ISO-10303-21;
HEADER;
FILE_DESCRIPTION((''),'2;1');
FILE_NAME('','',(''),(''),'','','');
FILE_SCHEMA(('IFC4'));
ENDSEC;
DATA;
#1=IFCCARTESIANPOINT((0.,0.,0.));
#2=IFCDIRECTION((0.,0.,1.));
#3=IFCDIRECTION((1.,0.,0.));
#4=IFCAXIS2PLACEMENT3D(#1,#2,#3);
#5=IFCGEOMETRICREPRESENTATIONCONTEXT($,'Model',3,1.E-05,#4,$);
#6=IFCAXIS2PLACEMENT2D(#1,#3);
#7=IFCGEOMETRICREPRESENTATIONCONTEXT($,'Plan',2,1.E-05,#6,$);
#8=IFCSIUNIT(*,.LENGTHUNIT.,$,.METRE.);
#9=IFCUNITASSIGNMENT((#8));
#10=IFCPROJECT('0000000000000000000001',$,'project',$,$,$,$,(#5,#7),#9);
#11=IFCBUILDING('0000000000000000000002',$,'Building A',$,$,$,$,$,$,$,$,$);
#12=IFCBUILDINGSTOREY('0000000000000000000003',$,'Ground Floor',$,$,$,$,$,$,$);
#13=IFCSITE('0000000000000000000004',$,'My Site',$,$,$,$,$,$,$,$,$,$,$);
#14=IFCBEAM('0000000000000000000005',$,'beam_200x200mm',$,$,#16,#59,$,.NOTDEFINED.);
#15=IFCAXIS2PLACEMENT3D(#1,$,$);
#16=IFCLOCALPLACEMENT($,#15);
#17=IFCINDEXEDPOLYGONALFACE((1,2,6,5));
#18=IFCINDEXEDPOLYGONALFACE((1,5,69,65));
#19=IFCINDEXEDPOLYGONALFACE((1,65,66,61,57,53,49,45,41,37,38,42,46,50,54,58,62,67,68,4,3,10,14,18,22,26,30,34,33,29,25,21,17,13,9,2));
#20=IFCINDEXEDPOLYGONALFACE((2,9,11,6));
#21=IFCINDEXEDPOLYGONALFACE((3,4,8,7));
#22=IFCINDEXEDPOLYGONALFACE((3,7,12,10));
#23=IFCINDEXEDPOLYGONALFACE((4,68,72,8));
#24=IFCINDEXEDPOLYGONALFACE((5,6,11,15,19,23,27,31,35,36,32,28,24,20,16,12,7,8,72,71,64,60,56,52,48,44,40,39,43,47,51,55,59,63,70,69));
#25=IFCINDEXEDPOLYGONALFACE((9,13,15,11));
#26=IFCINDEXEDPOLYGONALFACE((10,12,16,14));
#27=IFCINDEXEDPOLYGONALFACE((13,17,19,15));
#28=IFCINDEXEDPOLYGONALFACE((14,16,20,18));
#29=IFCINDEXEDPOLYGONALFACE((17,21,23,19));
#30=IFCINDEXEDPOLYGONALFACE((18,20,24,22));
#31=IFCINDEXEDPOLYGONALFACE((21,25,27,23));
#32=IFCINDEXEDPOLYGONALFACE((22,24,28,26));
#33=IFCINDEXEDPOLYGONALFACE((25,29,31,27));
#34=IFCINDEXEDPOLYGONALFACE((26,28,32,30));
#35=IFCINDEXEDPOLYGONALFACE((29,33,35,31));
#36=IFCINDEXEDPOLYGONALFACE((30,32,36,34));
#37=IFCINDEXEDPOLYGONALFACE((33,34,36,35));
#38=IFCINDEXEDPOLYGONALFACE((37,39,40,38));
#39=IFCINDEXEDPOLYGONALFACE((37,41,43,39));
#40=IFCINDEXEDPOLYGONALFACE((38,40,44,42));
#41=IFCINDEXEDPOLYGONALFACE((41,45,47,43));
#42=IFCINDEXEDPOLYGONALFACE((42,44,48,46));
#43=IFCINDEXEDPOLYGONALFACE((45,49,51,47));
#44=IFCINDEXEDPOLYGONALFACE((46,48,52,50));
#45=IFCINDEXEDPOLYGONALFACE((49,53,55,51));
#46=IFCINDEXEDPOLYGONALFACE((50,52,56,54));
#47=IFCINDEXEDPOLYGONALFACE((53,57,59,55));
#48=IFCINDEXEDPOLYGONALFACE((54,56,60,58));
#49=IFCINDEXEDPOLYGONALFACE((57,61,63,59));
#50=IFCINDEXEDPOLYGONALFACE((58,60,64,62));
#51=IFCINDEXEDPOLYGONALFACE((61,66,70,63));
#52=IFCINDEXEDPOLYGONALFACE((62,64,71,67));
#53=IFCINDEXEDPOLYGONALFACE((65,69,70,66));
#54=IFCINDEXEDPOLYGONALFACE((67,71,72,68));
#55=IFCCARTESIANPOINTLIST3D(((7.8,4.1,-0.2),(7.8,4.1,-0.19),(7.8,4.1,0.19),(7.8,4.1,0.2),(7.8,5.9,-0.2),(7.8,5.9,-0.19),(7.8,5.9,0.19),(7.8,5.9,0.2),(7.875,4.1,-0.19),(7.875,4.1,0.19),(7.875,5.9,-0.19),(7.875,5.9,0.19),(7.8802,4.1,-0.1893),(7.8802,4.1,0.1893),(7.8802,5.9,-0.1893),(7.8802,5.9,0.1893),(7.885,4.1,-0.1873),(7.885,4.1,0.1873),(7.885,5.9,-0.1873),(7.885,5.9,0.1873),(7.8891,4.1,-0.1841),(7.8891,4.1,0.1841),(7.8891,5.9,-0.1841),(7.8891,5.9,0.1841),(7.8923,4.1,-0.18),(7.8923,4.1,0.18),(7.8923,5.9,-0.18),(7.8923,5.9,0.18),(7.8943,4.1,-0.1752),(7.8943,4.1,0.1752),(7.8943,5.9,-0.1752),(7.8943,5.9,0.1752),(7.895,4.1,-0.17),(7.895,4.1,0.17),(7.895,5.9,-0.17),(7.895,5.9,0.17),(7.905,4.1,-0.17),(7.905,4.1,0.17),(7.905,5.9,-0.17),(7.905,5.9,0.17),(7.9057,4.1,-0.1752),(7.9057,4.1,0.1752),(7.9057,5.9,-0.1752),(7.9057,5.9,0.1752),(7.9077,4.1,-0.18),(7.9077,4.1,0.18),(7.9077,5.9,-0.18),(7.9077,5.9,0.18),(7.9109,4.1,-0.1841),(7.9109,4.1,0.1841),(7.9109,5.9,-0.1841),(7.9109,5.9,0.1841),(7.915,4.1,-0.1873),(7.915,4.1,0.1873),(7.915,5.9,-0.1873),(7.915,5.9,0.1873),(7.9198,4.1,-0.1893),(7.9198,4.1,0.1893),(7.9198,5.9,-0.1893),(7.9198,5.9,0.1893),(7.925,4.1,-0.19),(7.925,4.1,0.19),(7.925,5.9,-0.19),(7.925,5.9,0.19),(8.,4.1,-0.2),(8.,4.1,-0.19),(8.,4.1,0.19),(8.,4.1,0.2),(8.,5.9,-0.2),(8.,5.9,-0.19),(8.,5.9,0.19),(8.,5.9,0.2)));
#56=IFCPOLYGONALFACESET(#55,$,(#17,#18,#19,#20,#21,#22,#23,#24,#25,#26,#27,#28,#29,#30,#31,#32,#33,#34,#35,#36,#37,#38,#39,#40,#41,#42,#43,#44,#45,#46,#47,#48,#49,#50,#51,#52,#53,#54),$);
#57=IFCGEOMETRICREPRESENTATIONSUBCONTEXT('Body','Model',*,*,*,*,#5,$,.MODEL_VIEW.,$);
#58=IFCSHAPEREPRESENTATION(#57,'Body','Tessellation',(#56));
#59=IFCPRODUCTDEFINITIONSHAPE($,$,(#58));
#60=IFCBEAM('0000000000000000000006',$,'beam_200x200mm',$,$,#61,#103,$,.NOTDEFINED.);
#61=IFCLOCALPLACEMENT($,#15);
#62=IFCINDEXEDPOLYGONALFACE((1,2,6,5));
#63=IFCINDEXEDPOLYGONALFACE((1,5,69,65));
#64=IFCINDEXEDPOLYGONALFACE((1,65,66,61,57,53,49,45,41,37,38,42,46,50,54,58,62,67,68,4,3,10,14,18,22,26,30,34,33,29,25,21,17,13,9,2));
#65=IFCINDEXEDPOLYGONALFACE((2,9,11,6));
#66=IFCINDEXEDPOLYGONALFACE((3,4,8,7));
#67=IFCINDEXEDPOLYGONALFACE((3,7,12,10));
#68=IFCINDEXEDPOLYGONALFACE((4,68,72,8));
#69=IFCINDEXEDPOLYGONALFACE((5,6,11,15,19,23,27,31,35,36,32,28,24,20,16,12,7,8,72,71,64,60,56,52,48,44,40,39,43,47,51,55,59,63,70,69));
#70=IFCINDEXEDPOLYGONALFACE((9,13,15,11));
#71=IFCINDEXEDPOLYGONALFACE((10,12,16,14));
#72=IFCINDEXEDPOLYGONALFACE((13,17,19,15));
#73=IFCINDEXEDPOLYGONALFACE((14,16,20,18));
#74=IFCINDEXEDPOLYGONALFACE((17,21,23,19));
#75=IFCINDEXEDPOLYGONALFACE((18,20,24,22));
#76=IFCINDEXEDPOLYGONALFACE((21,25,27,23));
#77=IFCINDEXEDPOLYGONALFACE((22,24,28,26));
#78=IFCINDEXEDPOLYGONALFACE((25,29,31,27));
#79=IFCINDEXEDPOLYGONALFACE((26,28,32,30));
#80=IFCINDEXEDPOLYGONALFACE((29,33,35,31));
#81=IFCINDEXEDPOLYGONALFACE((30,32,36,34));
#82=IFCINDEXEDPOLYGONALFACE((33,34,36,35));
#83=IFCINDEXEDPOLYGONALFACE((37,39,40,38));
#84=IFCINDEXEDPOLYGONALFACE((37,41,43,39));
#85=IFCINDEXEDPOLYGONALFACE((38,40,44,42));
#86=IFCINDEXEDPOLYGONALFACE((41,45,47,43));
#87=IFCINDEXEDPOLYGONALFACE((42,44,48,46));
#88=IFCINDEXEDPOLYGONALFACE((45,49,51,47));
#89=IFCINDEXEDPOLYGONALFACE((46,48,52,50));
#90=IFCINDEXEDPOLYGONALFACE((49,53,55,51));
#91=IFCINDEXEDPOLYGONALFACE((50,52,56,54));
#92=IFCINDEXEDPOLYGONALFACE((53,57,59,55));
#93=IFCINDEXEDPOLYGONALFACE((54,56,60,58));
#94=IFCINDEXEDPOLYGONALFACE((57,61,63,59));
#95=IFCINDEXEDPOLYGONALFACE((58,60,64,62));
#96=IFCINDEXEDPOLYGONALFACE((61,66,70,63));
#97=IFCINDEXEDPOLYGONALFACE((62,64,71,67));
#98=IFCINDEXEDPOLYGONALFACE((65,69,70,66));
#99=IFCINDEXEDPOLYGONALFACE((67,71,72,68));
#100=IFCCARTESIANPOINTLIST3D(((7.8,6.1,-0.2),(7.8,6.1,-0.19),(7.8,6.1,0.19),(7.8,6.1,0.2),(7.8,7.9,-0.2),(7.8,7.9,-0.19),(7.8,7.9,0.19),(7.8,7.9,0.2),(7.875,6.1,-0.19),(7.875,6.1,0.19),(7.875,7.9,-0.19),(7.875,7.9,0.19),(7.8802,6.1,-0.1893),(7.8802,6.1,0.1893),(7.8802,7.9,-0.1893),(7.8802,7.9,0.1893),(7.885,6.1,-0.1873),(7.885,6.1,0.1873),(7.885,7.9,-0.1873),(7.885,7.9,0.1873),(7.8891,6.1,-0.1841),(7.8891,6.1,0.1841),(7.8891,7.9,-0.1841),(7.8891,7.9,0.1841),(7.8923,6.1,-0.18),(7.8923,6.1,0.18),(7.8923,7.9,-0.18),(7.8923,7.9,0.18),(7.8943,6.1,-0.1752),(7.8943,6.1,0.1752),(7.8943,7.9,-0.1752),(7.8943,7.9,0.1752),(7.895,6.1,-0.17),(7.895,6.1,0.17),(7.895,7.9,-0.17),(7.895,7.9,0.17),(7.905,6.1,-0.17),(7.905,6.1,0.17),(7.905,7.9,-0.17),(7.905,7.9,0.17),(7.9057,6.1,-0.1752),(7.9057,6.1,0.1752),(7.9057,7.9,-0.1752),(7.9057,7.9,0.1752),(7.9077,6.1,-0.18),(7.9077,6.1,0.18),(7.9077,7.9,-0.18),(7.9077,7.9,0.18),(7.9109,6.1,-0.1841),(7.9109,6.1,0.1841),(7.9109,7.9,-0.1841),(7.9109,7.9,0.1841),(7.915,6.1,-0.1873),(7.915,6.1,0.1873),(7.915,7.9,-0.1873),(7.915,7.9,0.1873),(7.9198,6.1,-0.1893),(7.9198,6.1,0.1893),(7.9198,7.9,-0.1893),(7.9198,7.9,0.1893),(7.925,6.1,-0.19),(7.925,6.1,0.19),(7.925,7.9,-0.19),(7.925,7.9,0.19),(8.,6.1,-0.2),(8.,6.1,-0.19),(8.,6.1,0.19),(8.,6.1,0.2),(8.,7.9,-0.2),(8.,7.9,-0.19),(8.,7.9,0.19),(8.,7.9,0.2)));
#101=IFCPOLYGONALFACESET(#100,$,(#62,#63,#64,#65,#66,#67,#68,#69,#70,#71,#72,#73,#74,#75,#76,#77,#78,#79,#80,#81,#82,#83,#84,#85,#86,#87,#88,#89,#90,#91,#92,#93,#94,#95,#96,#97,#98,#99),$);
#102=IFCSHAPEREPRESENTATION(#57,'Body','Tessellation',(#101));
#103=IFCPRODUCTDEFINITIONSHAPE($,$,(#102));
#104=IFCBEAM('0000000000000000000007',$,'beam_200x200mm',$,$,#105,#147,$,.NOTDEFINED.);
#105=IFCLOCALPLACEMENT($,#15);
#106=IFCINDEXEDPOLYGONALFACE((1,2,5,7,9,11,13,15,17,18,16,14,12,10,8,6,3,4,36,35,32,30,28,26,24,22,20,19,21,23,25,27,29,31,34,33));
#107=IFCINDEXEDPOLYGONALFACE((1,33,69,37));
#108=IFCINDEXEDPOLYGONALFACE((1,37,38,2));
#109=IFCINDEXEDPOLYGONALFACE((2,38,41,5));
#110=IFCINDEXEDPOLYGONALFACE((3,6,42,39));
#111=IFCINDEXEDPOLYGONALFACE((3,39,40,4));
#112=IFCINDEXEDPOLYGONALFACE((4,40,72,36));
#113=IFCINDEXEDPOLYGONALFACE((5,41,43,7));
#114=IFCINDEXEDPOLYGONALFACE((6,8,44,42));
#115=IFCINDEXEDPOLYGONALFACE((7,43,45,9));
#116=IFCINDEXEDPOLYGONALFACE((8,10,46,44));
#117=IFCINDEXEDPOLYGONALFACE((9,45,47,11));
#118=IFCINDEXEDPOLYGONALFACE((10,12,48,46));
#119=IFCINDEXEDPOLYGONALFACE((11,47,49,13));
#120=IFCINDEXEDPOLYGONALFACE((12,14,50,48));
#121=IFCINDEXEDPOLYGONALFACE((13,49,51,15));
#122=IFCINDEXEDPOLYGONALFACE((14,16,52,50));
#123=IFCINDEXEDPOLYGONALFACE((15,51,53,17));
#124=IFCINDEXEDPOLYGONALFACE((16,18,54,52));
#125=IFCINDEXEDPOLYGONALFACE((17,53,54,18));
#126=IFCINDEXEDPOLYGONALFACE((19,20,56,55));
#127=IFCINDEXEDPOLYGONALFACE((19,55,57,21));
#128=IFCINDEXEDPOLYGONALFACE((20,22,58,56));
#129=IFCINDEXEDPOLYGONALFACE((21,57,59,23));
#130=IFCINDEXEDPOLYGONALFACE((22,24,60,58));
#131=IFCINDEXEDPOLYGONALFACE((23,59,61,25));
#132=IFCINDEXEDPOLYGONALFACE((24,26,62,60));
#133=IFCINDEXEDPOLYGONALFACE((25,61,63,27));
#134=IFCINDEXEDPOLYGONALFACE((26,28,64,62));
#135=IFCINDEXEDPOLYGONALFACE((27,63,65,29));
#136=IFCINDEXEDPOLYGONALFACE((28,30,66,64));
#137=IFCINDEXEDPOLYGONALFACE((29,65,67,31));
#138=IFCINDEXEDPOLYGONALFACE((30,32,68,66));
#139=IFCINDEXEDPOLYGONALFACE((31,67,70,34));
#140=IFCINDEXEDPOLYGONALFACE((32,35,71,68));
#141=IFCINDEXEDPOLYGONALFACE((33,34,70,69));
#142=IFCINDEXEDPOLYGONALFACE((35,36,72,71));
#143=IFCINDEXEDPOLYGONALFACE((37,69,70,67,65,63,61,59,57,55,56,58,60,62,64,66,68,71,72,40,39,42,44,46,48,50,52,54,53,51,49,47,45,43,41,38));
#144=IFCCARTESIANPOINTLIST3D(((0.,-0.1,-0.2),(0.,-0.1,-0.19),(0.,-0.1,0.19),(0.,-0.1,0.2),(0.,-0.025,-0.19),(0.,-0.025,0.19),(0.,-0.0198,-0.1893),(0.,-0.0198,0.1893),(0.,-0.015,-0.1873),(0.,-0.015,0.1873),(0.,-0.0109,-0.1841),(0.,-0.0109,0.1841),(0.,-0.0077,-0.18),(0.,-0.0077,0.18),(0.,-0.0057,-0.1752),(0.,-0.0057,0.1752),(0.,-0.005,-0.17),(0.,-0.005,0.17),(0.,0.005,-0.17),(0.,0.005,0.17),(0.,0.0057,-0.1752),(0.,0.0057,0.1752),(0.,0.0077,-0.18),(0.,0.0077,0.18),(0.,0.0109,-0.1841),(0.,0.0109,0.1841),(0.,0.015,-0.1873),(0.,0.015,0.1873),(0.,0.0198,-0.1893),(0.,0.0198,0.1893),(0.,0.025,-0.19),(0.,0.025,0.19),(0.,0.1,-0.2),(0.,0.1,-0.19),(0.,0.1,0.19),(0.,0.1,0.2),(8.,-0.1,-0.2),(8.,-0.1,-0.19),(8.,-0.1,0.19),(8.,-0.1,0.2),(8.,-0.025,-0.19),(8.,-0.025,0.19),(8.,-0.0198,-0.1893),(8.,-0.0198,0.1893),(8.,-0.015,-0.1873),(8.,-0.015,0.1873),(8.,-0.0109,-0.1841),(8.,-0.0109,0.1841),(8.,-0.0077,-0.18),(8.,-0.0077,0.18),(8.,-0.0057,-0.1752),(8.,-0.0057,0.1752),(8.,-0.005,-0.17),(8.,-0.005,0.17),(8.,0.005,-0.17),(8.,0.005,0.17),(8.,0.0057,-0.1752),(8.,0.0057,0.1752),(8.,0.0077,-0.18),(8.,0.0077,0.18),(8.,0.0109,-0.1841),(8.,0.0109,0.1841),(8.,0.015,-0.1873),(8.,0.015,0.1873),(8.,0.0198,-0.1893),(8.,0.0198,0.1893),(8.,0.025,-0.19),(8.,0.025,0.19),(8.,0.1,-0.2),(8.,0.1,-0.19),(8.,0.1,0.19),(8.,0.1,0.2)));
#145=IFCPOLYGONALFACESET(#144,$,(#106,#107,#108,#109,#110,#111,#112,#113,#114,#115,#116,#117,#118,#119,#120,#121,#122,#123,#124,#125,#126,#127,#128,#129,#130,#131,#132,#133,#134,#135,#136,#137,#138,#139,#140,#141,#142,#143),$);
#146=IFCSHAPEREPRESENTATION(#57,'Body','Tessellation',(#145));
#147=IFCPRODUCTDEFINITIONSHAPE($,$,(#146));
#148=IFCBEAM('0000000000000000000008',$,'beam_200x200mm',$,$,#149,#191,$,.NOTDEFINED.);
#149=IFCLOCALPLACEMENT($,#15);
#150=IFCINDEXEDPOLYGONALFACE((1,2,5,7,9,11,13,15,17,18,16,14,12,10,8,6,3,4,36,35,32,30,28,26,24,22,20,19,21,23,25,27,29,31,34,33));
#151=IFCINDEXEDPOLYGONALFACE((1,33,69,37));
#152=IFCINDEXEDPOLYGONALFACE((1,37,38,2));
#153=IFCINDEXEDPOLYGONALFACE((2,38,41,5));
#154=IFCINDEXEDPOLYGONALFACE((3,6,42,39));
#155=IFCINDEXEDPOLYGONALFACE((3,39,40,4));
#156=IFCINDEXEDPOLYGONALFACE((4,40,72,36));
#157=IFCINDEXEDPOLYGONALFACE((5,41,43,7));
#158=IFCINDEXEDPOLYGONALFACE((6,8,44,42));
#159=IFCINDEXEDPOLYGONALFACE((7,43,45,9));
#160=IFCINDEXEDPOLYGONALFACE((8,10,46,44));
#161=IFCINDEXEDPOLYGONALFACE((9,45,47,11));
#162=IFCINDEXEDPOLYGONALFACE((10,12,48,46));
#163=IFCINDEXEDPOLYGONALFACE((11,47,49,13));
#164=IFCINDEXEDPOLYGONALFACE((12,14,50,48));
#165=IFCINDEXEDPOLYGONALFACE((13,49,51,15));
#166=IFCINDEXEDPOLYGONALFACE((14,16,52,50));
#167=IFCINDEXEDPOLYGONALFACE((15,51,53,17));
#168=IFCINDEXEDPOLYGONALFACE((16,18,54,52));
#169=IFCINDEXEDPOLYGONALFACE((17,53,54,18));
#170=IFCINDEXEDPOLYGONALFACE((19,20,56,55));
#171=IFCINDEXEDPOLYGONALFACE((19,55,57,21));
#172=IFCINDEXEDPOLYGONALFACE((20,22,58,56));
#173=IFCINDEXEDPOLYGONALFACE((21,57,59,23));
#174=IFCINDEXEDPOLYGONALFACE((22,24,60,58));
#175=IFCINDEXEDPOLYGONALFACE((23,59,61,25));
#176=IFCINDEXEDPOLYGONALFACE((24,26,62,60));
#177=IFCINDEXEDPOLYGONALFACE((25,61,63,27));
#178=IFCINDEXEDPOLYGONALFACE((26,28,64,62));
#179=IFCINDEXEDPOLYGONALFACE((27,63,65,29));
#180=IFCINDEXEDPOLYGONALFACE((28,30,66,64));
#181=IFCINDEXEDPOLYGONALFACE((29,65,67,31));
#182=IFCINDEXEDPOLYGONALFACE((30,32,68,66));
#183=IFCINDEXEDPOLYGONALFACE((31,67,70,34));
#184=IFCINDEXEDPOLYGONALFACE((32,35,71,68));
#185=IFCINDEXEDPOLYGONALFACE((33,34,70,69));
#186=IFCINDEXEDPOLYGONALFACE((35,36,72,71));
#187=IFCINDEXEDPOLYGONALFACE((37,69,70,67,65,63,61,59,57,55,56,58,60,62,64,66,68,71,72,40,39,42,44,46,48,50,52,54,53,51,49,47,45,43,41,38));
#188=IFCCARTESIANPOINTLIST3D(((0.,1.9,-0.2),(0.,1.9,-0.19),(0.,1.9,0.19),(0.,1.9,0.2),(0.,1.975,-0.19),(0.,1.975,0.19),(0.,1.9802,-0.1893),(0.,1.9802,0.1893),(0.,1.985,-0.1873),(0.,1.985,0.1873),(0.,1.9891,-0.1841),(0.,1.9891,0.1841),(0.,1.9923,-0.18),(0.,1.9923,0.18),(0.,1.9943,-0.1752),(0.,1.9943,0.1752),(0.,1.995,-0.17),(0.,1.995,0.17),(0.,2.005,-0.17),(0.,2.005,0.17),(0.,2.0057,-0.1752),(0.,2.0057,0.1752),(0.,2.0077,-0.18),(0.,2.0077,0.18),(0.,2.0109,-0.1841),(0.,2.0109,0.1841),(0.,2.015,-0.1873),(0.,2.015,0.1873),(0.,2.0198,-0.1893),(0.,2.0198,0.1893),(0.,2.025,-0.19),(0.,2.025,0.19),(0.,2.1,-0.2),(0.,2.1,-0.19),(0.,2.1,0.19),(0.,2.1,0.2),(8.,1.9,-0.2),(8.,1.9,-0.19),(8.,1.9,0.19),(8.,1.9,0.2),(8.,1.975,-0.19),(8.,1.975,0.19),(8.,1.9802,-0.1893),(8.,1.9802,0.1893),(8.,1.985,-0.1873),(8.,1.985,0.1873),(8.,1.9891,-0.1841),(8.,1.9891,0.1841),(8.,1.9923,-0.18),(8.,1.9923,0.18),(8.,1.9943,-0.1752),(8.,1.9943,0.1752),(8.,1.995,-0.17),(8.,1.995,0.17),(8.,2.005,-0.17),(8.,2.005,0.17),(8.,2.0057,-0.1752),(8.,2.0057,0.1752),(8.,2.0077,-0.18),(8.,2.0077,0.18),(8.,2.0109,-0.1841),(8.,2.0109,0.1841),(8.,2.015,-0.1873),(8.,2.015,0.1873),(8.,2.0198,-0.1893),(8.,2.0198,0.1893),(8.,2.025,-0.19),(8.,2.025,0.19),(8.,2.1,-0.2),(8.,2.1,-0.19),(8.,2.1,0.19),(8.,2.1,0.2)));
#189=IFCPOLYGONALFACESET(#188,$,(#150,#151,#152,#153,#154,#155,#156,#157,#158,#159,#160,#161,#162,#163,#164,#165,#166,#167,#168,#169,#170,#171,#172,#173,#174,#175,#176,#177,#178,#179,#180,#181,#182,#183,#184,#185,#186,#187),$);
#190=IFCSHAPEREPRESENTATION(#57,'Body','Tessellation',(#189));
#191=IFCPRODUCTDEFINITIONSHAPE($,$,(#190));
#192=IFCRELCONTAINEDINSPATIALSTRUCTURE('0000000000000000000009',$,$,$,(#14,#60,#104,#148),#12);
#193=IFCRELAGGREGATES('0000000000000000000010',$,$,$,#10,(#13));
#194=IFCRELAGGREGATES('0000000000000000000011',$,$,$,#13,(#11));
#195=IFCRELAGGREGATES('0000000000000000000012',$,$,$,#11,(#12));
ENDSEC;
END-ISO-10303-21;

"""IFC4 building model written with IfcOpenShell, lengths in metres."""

from ifc_helpers import new_model, entity, si_unit, frame, frame_2d, origin_with_axes, place, context, subcontext, project, spatial, extrude, element, save


model = new_model("IFC4")

# Units and contexts
model_context = context("Model", 3, precision=1e-05, world=origin_with_axes())
plan_context = context("Plan", 2, precision=1e-05, world=frame_2d((0.0, 0.0, 0.0), x_axis=(1.0, 0.0, 0.0)))
body_context = subcontext(model_context, "Body", "Model", "MODEL_VIEW")
ifc_project = project(units=[si_unit("LENGTHUNIT", "METRE")], contexts=[model_context, plan_context])

# Site, building, storey
site = spatial("IfcSite", under=ifc_project, Name="My Site")
building = spatial("IfcBuilding", under=site, Name="Building A")
storey = spatial("IfcBuildingStorey", under=building, Name="Ground Floor")

# Beams
for number, where, z_axis, x_axis, name in (
    (1, (7.9, 4.1, 0.0), (0.0, 1.0, 0.0), (1.0, 1.0, 0.0), "beam_200x200mm"),
    (2, (7.9, 6.1, 0.0), (0.0, 1.0, 0.0), (1.0, 1.0, 0.0), "beam_200x200mm"),
):
    element("IfcBeam", number, at=place(None, frame(where, z_axis=z_axis, x_axis=x_axis)), inside=storey, Name=name, PredefinedType="NOTDEFINED", context=body_context, shape_type="SweptSolid", body=[
        extrude(entity("IfcIShapeProfileDef", None, None, None, 0.2, 0.4, 0.01, 0.01, 0.02), origin_with_axes(), (0.0, 0.0, 1.0), 1.8),
    ])
for number, where, z_axis, x_axis, name in (
    (3, (0.0, 0.0, 0.0), (1.0, 0.0, 0.0), (0.0, 1.0, 0.0), "beam_200x200mm"),
    (4, (0.0, 2.0, 0.0), (1.0, 0.0, 0.0), (0.0, 1.0, 0.0), "beam_200x200mm"),
):
    element("IfcBeam", number, at=place(None, frame(where, z_axis=z_axis, x_axis=x_axis)), inside=storey, Name=name, PredefinedType="NOTDEFINED", context=body_context, shape_type="SweptSolid", body=[
        extrude(entity("IfcIShapeProfileDef", None, None, None, 0.2, 0.4, 0.01, 0.01, 0.02), origin_with_axes(), (0.0, 0.0, 1.0), 8.0),
    ])

save(model, "model.ifc")
